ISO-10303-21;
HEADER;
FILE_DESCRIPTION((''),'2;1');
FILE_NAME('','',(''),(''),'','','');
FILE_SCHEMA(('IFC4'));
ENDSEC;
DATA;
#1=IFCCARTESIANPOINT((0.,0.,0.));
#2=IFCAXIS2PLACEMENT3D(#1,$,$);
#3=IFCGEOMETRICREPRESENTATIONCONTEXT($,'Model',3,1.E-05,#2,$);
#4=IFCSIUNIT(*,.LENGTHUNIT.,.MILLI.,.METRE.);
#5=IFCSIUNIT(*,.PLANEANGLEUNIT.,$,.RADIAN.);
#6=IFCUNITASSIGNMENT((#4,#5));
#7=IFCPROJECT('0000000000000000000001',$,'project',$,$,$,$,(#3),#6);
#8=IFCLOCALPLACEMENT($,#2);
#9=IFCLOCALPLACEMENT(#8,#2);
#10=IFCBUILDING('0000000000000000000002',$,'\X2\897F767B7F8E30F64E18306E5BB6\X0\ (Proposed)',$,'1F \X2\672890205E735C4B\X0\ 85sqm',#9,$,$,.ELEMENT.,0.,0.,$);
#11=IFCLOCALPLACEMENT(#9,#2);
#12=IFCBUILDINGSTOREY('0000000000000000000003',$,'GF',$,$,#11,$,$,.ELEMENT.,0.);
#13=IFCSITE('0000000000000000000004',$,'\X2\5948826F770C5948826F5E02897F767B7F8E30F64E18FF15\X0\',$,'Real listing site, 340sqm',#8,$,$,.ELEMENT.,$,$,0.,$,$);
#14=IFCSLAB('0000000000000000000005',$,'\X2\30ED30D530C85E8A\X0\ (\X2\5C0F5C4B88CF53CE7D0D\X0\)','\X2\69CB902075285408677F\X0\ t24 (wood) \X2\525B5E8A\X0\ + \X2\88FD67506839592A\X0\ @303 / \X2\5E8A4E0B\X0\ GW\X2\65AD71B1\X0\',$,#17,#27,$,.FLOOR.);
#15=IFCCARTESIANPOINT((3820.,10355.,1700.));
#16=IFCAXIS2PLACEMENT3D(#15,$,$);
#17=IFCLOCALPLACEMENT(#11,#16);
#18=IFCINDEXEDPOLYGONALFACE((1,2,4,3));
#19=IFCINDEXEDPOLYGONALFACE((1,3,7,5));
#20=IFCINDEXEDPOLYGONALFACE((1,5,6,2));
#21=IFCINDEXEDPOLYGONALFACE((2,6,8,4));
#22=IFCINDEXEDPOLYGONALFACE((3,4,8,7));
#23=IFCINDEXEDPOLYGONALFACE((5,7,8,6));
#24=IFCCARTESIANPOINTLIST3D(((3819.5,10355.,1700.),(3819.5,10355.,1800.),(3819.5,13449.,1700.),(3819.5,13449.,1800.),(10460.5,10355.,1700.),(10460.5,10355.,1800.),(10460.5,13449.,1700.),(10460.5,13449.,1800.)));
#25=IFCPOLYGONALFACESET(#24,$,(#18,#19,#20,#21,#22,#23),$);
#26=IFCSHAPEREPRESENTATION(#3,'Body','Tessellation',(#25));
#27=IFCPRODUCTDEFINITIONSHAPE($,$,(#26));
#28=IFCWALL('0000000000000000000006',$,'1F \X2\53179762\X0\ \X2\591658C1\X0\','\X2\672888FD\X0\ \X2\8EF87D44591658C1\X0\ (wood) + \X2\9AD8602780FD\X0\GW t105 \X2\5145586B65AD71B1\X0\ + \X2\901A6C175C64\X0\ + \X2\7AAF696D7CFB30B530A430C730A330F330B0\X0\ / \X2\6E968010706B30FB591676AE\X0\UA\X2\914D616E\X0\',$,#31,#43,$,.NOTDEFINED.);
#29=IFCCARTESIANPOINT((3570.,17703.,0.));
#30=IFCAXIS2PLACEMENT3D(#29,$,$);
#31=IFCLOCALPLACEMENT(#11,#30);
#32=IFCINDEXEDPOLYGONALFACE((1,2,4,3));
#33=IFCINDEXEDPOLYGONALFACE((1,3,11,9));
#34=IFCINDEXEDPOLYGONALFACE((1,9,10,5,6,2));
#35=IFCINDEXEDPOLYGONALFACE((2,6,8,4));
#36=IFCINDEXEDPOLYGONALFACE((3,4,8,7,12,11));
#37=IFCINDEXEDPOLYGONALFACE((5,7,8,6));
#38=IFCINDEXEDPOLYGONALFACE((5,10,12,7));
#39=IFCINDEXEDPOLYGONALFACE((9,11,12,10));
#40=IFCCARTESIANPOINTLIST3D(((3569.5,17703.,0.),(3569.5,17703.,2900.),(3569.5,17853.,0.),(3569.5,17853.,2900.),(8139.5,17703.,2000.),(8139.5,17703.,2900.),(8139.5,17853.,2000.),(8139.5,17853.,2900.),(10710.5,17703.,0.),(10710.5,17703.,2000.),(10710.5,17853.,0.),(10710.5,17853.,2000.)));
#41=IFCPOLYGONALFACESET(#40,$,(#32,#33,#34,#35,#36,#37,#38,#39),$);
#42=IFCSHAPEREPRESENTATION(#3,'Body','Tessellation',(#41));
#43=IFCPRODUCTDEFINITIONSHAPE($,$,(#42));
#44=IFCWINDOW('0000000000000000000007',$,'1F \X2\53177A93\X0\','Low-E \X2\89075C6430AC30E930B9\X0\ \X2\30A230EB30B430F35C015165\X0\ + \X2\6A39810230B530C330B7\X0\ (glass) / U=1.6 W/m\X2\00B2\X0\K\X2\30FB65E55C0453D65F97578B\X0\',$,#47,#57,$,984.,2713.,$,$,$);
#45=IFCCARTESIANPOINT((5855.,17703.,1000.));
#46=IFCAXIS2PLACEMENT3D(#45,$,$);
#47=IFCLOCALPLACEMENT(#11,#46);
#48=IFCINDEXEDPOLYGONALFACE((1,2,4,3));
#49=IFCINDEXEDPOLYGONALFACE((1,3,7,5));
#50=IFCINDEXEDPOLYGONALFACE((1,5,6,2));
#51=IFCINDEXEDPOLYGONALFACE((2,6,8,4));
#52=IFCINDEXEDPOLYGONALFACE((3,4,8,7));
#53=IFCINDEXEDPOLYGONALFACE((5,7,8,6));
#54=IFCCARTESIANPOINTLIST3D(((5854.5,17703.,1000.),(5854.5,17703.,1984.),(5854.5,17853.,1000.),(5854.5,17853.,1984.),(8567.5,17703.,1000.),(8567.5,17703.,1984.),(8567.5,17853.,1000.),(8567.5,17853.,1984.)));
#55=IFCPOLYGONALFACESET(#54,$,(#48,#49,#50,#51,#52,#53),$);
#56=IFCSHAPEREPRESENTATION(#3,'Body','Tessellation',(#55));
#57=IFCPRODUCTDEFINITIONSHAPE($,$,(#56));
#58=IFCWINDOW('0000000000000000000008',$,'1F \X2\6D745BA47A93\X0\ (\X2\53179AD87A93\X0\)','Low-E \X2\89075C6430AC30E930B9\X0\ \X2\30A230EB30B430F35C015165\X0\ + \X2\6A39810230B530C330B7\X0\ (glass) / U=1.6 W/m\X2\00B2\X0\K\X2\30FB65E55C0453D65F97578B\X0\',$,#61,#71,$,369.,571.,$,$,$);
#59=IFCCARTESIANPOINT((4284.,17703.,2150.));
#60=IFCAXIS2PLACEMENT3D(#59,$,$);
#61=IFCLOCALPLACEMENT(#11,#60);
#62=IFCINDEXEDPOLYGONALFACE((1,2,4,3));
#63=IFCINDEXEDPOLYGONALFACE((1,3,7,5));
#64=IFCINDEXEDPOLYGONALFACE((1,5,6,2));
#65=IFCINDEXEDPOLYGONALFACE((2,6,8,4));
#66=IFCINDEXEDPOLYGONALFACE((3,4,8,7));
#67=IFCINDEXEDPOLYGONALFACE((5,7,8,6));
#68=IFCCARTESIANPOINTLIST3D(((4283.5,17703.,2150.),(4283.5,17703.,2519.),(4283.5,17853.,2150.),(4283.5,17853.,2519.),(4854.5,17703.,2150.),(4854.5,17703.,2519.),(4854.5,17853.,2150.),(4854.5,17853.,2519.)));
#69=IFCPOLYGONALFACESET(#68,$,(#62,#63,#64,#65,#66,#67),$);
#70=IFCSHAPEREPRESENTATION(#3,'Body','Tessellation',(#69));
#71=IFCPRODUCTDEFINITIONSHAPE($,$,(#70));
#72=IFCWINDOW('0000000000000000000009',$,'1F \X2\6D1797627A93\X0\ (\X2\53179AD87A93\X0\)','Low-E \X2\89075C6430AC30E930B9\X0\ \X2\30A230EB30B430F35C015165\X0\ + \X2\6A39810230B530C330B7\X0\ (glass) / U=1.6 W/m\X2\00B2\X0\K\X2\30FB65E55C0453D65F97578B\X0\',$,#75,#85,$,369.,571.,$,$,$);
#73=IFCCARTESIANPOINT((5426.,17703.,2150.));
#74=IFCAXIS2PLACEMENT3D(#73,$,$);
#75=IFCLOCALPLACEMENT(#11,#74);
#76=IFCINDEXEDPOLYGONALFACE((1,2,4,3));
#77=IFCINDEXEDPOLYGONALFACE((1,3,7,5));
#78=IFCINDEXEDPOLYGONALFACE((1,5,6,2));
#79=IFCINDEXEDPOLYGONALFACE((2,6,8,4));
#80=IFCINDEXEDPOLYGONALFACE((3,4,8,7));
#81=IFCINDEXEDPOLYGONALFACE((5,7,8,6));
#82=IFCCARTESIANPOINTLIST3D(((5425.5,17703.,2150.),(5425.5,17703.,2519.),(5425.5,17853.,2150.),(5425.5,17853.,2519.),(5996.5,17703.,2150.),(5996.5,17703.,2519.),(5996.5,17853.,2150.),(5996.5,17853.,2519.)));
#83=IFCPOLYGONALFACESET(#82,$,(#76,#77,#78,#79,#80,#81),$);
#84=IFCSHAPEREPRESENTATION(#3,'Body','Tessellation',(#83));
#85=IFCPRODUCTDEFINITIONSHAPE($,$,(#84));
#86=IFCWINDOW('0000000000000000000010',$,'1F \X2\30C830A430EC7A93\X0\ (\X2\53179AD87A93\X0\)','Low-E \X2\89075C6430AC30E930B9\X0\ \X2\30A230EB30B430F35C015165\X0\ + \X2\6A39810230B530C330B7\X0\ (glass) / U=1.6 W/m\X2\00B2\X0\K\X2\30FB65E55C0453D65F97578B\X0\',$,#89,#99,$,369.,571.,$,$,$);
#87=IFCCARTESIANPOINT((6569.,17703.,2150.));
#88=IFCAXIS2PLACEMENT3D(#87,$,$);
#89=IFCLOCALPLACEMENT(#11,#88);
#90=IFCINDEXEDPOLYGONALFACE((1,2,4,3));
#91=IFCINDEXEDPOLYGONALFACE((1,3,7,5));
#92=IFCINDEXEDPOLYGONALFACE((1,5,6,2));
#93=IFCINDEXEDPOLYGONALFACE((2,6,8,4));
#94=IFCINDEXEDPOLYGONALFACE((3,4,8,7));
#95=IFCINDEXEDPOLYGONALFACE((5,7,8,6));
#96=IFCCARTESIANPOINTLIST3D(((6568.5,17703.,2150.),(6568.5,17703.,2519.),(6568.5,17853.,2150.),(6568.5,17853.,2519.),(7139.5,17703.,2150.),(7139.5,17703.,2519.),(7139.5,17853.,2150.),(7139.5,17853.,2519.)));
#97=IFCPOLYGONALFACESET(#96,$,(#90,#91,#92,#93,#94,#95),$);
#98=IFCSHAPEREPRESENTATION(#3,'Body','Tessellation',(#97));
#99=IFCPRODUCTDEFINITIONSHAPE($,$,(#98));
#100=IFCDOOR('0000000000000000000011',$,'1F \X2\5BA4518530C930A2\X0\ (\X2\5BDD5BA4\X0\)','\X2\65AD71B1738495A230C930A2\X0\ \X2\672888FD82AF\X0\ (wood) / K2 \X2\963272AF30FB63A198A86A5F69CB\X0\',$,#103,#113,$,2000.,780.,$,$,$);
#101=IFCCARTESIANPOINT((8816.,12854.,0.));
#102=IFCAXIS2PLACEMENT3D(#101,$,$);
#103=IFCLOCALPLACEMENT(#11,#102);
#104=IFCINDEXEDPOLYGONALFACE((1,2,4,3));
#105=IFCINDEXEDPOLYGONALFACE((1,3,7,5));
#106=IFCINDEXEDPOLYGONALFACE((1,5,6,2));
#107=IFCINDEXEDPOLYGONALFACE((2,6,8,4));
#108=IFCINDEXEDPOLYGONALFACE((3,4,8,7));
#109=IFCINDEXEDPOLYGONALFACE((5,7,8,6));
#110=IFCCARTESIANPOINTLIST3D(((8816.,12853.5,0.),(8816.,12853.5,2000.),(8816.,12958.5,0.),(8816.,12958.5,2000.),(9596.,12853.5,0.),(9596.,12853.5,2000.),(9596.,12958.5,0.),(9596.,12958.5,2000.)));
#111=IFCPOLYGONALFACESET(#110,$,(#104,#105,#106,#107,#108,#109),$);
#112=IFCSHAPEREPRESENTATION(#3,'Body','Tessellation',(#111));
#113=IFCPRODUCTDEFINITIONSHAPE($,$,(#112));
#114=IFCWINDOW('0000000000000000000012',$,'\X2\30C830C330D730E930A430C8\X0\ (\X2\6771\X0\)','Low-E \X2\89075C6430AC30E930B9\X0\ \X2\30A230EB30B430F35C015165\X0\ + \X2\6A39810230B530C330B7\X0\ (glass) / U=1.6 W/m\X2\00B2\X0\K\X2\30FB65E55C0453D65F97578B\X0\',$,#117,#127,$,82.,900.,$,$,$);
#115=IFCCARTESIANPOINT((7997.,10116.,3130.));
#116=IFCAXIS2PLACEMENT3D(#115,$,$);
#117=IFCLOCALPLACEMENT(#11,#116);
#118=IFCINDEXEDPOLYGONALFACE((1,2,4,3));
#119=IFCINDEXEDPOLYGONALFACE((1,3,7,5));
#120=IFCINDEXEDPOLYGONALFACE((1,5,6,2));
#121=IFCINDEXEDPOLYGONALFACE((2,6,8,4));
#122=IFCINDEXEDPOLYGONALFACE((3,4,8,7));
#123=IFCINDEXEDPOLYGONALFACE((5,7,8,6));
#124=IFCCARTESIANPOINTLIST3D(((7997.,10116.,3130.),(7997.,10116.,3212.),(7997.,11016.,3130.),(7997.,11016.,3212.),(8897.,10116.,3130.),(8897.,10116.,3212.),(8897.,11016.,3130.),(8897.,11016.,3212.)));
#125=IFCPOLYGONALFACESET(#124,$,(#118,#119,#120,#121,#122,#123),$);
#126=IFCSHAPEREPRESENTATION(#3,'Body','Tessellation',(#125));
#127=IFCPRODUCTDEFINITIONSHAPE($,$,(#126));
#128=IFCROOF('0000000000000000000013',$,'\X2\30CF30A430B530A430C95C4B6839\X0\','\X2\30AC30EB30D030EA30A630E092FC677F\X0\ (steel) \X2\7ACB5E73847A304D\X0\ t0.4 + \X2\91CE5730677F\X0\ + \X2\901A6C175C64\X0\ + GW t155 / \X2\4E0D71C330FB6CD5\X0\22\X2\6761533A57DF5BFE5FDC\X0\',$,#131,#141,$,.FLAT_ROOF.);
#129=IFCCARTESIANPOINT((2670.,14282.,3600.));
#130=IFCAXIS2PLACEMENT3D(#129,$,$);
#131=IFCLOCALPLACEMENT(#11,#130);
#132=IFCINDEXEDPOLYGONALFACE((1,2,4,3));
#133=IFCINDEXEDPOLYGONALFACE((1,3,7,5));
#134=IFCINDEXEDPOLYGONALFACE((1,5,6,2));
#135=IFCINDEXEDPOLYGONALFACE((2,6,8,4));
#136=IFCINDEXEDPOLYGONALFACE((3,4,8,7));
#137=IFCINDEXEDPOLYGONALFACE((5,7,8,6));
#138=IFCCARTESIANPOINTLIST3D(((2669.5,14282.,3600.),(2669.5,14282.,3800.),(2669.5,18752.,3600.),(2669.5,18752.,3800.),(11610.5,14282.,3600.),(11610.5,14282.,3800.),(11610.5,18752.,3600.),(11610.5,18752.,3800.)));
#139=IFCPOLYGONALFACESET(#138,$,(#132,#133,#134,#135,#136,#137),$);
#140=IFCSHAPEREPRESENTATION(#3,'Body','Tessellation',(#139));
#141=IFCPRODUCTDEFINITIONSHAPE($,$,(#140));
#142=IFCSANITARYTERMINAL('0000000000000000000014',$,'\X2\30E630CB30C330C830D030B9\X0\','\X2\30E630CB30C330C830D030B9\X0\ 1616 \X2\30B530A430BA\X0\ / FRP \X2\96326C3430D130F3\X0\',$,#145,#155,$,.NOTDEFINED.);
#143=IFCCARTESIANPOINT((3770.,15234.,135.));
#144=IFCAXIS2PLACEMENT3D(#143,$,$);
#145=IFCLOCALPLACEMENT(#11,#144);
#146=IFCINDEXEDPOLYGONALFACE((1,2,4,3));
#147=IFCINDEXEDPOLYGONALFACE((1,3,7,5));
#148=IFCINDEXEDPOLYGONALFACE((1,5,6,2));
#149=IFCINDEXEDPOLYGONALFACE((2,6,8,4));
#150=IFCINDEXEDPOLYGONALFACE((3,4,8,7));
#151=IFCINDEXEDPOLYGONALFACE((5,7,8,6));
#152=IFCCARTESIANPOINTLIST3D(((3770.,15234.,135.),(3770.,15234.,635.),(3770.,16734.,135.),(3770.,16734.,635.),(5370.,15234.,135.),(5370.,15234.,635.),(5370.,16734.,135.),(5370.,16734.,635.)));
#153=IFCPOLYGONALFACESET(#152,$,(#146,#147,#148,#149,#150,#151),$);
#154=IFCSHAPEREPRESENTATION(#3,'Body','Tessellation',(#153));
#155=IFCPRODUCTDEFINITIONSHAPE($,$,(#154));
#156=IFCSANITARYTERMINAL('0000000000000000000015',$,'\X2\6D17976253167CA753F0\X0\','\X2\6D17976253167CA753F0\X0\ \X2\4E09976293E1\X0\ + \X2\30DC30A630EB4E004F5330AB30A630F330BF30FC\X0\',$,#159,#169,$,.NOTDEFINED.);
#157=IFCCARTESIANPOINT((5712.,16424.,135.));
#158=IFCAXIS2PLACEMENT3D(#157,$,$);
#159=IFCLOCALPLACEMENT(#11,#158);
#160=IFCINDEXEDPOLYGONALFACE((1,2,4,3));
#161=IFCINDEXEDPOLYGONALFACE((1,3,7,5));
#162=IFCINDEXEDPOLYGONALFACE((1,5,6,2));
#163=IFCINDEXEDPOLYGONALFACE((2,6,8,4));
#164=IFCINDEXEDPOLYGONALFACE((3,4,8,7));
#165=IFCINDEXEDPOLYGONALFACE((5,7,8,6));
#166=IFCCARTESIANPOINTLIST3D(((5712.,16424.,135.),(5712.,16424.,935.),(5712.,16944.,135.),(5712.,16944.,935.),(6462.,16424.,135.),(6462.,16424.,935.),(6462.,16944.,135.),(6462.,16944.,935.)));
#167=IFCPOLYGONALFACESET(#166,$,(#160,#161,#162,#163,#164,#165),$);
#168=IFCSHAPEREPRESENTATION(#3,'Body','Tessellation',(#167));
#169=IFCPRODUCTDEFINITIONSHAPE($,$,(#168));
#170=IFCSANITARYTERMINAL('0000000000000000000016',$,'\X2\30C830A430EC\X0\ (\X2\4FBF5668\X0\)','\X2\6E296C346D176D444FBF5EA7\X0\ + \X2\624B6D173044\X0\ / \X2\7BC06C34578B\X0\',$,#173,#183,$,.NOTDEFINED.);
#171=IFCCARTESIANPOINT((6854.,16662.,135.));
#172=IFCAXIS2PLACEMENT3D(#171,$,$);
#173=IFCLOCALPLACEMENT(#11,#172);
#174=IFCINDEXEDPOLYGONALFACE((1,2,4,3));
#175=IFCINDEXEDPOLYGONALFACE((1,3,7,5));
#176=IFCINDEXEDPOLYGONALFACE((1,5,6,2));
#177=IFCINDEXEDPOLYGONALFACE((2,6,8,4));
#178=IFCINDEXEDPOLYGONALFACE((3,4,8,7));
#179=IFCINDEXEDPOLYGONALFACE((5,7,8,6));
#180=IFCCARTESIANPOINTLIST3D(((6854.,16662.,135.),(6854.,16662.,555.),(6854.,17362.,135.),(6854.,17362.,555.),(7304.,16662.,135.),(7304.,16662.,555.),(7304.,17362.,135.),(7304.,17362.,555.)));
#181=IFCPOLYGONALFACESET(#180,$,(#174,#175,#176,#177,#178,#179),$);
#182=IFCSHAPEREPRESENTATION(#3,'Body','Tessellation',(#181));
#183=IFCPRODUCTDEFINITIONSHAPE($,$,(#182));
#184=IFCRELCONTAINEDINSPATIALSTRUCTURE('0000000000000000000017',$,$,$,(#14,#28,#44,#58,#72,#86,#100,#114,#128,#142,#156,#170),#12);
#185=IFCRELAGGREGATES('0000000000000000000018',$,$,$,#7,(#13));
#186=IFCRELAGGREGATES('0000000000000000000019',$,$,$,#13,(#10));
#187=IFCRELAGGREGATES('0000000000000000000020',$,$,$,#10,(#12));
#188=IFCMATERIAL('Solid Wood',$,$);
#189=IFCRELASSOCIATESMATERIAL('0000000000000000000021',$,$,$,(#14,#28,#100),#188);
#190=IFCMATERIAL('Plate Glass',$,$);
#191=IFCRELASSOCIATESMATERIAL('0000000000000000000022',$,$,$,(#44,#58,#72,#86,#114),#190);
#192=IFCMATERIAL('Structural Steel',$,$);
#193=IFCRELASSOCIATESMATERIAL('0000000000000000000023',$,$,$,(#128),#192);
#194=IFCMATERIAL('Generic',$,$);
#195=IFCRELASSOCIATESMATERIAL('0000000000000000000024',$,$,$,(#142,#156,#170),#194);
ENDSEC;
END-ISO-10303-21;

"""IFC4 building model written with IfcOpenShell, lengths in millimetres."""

from ifc_helpers import new_model, si_unit, frame, frame_2d, origin, place, context, project, spatial, rectangle, extrude, material, element, fill, save


model = new_model("IFC4")

# Units and contexts
model_context = context("Model", 3, precision=1e-05, world=origin())
ifc_project = project(units=[si_unit("LENGTHUNIT", "METRE", prefix="MILLI"), si_unit("PLANEANGLEUNIT", "RADIAN")], contexts=[model_context])

# Site, building, storey
site_placement = place(None, origin())
site = spatial("IfcSite", under=ifc_project, at=site_placement, Name="奈良県奈良市西登美ヶ丘５", ObjectType="Real listing site, 340sqm", CompositionType="ELEMENT", RefElevation=0.0)
building_placement = place(site_placement, origin())
building = spatial("IfcBuilding", under=site, at=building_placement, Name="西登美ヶ丘の家 (Proposed)", ObjectType="1F 木造平屋 85sqm", CompositionType="ELEMENT", ElevationOfRefHeight=0.0, ElevationOfTerrain=0.0)
storey_placement = place(building_placement, origin())
storey = spatial("IfcBuildingStorey", under=building, at=storey_placement, Name="GF", CompositionType="ELEMENT", Elevation=0.0)

# Slab
ifc_material_1 = material(Name="Solid Wood")
slab_placement = place(storey_placement, frame((3820.0, 10355.0, 1700.0)))
element("IfcSlab", 1, at=slab_placement, inside=storey, material=ifc_material_1, Name="ロフト床 (小屋裏収納)", Description="構造用合板 t24 (wood) 剛床 + 製材根太 @303 / 床下 GW断熱", PredefinedType="FLOOR", context=model_context, shape_type="SweptSolid", body=[
    extrude(rectangle(XDim=6641.0, YDim=3094.0, at=frame_2d((3320.0, 1547.0))), frame((3820.0, 10355.0, 1700.0)), (0.0, 0.0, 1.0), 100.0),
])

# Wall, openings, windows
wall_1_placement = place(storey_placement, frame((3570.0, 17703.0, 0.0)))
wall_1 = element("IfcWall", 2, at=wall_1_placement, inside=storey, material=ifc_material_1, Name="1F 北面 外壁", Description="木製 軸組外壁 (wood) + 高性能GW t105 充填断熱 + 通気層 + 窯業系サイディング / 準耐火・外皮UA配慮", PredefinedType="NOTDEFINED", context=model_context, shape_type="SweptSolid", body=[
    extrude(rectangle(XDim=7141.0, YDim=150.0, at=frame_2d((3570.0, 75.0))), frame((3570.0, 17703.0, 0.0)), (0.0, 0.0, 1.0), 2900.0),
])
opening_1_placement = place(storey_placement, frame((5855.0, 17703.0, 1000.0)))
opening_1 = element("IfcOpeningElement", 3, at=opening_1_placement, cuts=wall_1, PredefinedType="NOTDEFINED", context=model_context, shape_type="SweptSolid", body=[
    extrude(rectangle(XDim=2713.0, YDim=150.0, at=frame_2d((1356.0, 75.0))), frame((5855.0, 17703.0, 1000.0)), (0.0, 0.0, 1.0), 984.0),
])
opening_2_placement = place(storey_placement, frame((4284.0, 17703.0, 2150.0)))
opening_2 = element("IfcOpeningElement", 4, at=opening_2_placement, cuts=wall_1, PredefinedType="NOTDEFINED", context=model_context, shape_type="SweptSolid", body=[
    extrude(rectangle(XDim=571.0, YDim=150.0, at=frame_2d((285.0, 75.0))), frame((4284.0, 17703.0, 2150.0)), (0.0, 0.0, 1.0), 369.0),
])
opening_3_placement = place(storey_placement, frame((5426.0, 17703.0, 2150.0)))
opening_3 = element("IfcOpeningElement", 5, at=opening_3_placement, cuts=wall_1, PredefinedType="NOTDEFINED", context=model_context, shape_type="SweptSolid", body=[
    extrude(rectangle(XDim=571.0, YDim=150.0, at=frame_2d((285.0, 75.0))), frame((5426.0, 17703.0, 2150.0)), (0.0, 0.0, 1.0), 369.0),
])
opening_4_placement = place(storey_placement, frame((6569.0, 17703.0, 2150.0)))
opening_4 = element("IfcOpeningElement", 6, at=opening_4_placement, cuts=wall_1, PredefinedType="NOTDEFINED", context=model_context, shape_type="SweptSolid", body=[
    extrude(rectangle(XDim=571.0, YDim=150.0, at=frame_2d((285.0, 75.0))), frame((6569.0, 17703.0, 2150.0)), (0.0, 0.0, 1.0), 369.0),
])
ifc_material_2 = material(Name="Plate Glass")
window_1_placement = place(storey_placement, frame((5855.0, 17703.0, 1000.0)))
window_1 = element("IfcWindow", 7, at=window_1_placement, inside=storey, material=ifc_material_2, Name="1F 北窓", Description="Low-E 複層ガラス アルゴン封入 + 樹脂サッシ (glass) / U=1.6 W/m²K・日射取得型", OverallHeight=984.0, OverallWidth=2713.0, context=model_context, shape_type="SweptSolid", body=[
    extrude(rectangle(XDim=2713.0, YDim=150.0, at=frame_2d((1356.0, 75.0))), frame((5855.0, 17703.0, 1000.0)), (0.0, 0.0, 1.0), 984.0),
])
fill(opening_1, window_1)
window_2_placement = place(storey_placement, frame((4284.0, 17703.0, 2150.0)))
window_2 = element("IfcWindow", 8, at=window_2_placement, inside=storey, material=ifc_material_2, Name="1F 浴室窓 (北高窓)", Description="Low-E 複層ガラス アルゴン封入 + 樹脂サッシ (glass) / U=1.6 W/m²K・日射取得型", OverallHeight=369.0, OverallWidth=571.0, context=model_context, shape_type="SweptSolid", body=[
    extrude(rectangle(XDim=571.0, YDim=150.0, at=frame_2d((285.0, 75.0))), frame((4284.0, 17703.0, 2150.0)), (0.0, 0.0, 1.0), 369.0),
])
fill(opening_2, window_2)
window_3_placement = place(storey_placement, frame((5426.0, 17703.0, 2150.0)))
window_3 = element("IfcWindow", 9, at=window_3_placement, inside=storey, material=ifc_material_2, Name="1F 洗面窓 (北高窓)", Description="Low-E 複層ガラス アルゴン封入 + 樹脂サッシ (glass) / U=1.6 W/m²K・日射取得型", OverallHeight=369.0, OverallWidth=571.0, context=model_context, shape_type="SweptSolid", body=[
    extrude(rectangle(XDim=571.0, YDim=150.0, at=frame_2d((285.0, 75.0))), frame((5426.0, 17703.0, 2150.0)), (0.0, 0.0, 1.0), 369.0),
])
fill(opening_3, window_3)
window_4_placement = place(storey_placement, frame((6569.0, 17703.0, 2150.0)))
window_4 = element("IfcWindow", 10, at=window_4_placement, inside=storey, material=ifc_material_2, Name="1F トイレ窓 (北高窓)", Description="Low-E 複層ガラス アルゴン封入 + 樹脂サッシ (glass) / U=1.6 W/m²K・日射取得型", OverallHeight=369.0, OverallWidth=571.0, context=model_context, shape_type="SweptSolid", body=[
    extrude(rectangle(XDim=571.0, YDim=150.0, at=frame_2d((285.0, 75.0))), frame((6569.0, 17703.0, 2150.0)), (0.0, 0.0, 1.0), 369.0),
])
fill(opening_4, window_4)

# Door
door_1_placement = place(storey_placement, frame((8816.0, 12854.0, 0.0)))
element("IfcDoor", 11, at=door_1_placement, inside=storey, material=ifc_material_1, Name="1F 室内ドア (寝室)", Description="断熱玄関ドア 木製芯 (wood) / K2 防犯・採風機構", OverallHeight=2000.0, OverallWidth=780.0, context=model_context, shape_type="SweptSolid", body=[
    extrude(rectangle(XDim=780.0, YDim=105.0, at=frame_2d((390.0, 52.0))), frame((8816.0, 12854.0, 0.0)), (0.0, 0.0, 1.0), 2000.0),
])

# Window
window_5_placement = place(storey_placement, frame((7997.0, 10116.0, 3130.0)))
element("IfcWindow", 12, at=window_5_placement, inside=storey, material=ifc_material_2, Name="トップライト (東)", Description="Low-E 複層ガラス アルゴン封入 + 樹脂サッシ (glass) / U=1.6 W/m²K・日射取得型", OverallHeight=82.0, OverallWidth=900.0, context=model_context, shape_type="SweptSolid", body=[
    extrude(rectangle(XDim=900.0, YDim=900.0, at=frame_2d((450.0, 450.0))), frame((7997.0, 10116.0, 3130.0)), (0.0, 0.0, 1.0), 82.0),
])

# Roof
ifc_material_3 = material(Name="Structural Steel")
roof_placement = place(storey_placement, frame((2670.0, 14282.0, 3600.0)))
element("IfcRoof", 13, at=roof_placement, inside=storey, material=ifc_material_3, Name="ハイサイド屋根", Description="ガルバリウム鋼板 (steel) 立平葺き t0.4 + 野地板 + 通気層 + GW t155 / 不燃・法22条区域対応", PredefinedType="FLAT_ROOF", context=model_context, shape_type="SweptSolid", body=[
    extrude(rectangle(XDim=8941.0, YDim=4470.0, at=frame_2d((4470.0, 2235.0))), frame((2670.0, 14282.0, 3600.0)), (0.0, 0.0, 1.0), 200.0),
])

# Sanitary terminals
ifc_material_4 = material(Name="Generic")
sanitary_terminal_1_placement = place(storey_placement, frame((3770.0, 15234.0, 135.0)))
element("IfcSanitaryTerminal", 14, at=sanitary_terminal_1_placement, inside=storey, material=ifc_material_4, Name="ユニットバス", Description="ユニットバス 1616 サイズ / FRP 防水パン", PredefinedType="NOTDEFINED", context=model_context, shape_type="SweptSolid", body=[
    extrude(rectangle(XDim=1600.0, YDim=1500.0, at=frame_2d((800.0, 750.0))), frame((3770.0, 15234.0, 135.0)), (0.0, 0.0, 1.0), 500.0),
])
sanitary_terminal_2_placement = place(storey_placement, frame((5712.0, 16424.0, 135.0)))
element("IfcSanitaryTerminal", 15, at=sanitary_terminal_2_placement, inside=storey, material=ifc_material_4, Name="洗面化粧台", Description="洗面化粧台 三面鏡 + ボウル一体カウンター", PredefinedType="NOTDEFINED", context=model_context, shape_type="SweptSolid", body=[
    extrude(rectangle(XDim=750.0, YDim=520.0, at=frame_2d((375.0, 260.0))), frame((5712.0, 16424.0, 135.0)), (0.0, 0.0, 1.0), 800.0),
])
sanitary_terminal_3_placement = place(storey_placement, frame((6854.0, 16662.0, 135.0)))
element("IfcSanitaryTerminal", 16, at=sanitary_terminal_3_placement, inside=storey, material=ifc_material_4, Name="トイレ (便器)", Description="温水洗浄便座 + 手洗い / 節水型", PredefinedType="NOTDEFINED", context=model_context, shape_type="SweptSolid", body=[
    extrude(rectangle(XDim=450.0, YDim=700.0, at=frame_2d((225.0, 350.0))), frame((6854.0, 16662.0, 135.0)), (0.0, 0.0, 1.0), 420.0),
])

save(model, "model.ifc")
